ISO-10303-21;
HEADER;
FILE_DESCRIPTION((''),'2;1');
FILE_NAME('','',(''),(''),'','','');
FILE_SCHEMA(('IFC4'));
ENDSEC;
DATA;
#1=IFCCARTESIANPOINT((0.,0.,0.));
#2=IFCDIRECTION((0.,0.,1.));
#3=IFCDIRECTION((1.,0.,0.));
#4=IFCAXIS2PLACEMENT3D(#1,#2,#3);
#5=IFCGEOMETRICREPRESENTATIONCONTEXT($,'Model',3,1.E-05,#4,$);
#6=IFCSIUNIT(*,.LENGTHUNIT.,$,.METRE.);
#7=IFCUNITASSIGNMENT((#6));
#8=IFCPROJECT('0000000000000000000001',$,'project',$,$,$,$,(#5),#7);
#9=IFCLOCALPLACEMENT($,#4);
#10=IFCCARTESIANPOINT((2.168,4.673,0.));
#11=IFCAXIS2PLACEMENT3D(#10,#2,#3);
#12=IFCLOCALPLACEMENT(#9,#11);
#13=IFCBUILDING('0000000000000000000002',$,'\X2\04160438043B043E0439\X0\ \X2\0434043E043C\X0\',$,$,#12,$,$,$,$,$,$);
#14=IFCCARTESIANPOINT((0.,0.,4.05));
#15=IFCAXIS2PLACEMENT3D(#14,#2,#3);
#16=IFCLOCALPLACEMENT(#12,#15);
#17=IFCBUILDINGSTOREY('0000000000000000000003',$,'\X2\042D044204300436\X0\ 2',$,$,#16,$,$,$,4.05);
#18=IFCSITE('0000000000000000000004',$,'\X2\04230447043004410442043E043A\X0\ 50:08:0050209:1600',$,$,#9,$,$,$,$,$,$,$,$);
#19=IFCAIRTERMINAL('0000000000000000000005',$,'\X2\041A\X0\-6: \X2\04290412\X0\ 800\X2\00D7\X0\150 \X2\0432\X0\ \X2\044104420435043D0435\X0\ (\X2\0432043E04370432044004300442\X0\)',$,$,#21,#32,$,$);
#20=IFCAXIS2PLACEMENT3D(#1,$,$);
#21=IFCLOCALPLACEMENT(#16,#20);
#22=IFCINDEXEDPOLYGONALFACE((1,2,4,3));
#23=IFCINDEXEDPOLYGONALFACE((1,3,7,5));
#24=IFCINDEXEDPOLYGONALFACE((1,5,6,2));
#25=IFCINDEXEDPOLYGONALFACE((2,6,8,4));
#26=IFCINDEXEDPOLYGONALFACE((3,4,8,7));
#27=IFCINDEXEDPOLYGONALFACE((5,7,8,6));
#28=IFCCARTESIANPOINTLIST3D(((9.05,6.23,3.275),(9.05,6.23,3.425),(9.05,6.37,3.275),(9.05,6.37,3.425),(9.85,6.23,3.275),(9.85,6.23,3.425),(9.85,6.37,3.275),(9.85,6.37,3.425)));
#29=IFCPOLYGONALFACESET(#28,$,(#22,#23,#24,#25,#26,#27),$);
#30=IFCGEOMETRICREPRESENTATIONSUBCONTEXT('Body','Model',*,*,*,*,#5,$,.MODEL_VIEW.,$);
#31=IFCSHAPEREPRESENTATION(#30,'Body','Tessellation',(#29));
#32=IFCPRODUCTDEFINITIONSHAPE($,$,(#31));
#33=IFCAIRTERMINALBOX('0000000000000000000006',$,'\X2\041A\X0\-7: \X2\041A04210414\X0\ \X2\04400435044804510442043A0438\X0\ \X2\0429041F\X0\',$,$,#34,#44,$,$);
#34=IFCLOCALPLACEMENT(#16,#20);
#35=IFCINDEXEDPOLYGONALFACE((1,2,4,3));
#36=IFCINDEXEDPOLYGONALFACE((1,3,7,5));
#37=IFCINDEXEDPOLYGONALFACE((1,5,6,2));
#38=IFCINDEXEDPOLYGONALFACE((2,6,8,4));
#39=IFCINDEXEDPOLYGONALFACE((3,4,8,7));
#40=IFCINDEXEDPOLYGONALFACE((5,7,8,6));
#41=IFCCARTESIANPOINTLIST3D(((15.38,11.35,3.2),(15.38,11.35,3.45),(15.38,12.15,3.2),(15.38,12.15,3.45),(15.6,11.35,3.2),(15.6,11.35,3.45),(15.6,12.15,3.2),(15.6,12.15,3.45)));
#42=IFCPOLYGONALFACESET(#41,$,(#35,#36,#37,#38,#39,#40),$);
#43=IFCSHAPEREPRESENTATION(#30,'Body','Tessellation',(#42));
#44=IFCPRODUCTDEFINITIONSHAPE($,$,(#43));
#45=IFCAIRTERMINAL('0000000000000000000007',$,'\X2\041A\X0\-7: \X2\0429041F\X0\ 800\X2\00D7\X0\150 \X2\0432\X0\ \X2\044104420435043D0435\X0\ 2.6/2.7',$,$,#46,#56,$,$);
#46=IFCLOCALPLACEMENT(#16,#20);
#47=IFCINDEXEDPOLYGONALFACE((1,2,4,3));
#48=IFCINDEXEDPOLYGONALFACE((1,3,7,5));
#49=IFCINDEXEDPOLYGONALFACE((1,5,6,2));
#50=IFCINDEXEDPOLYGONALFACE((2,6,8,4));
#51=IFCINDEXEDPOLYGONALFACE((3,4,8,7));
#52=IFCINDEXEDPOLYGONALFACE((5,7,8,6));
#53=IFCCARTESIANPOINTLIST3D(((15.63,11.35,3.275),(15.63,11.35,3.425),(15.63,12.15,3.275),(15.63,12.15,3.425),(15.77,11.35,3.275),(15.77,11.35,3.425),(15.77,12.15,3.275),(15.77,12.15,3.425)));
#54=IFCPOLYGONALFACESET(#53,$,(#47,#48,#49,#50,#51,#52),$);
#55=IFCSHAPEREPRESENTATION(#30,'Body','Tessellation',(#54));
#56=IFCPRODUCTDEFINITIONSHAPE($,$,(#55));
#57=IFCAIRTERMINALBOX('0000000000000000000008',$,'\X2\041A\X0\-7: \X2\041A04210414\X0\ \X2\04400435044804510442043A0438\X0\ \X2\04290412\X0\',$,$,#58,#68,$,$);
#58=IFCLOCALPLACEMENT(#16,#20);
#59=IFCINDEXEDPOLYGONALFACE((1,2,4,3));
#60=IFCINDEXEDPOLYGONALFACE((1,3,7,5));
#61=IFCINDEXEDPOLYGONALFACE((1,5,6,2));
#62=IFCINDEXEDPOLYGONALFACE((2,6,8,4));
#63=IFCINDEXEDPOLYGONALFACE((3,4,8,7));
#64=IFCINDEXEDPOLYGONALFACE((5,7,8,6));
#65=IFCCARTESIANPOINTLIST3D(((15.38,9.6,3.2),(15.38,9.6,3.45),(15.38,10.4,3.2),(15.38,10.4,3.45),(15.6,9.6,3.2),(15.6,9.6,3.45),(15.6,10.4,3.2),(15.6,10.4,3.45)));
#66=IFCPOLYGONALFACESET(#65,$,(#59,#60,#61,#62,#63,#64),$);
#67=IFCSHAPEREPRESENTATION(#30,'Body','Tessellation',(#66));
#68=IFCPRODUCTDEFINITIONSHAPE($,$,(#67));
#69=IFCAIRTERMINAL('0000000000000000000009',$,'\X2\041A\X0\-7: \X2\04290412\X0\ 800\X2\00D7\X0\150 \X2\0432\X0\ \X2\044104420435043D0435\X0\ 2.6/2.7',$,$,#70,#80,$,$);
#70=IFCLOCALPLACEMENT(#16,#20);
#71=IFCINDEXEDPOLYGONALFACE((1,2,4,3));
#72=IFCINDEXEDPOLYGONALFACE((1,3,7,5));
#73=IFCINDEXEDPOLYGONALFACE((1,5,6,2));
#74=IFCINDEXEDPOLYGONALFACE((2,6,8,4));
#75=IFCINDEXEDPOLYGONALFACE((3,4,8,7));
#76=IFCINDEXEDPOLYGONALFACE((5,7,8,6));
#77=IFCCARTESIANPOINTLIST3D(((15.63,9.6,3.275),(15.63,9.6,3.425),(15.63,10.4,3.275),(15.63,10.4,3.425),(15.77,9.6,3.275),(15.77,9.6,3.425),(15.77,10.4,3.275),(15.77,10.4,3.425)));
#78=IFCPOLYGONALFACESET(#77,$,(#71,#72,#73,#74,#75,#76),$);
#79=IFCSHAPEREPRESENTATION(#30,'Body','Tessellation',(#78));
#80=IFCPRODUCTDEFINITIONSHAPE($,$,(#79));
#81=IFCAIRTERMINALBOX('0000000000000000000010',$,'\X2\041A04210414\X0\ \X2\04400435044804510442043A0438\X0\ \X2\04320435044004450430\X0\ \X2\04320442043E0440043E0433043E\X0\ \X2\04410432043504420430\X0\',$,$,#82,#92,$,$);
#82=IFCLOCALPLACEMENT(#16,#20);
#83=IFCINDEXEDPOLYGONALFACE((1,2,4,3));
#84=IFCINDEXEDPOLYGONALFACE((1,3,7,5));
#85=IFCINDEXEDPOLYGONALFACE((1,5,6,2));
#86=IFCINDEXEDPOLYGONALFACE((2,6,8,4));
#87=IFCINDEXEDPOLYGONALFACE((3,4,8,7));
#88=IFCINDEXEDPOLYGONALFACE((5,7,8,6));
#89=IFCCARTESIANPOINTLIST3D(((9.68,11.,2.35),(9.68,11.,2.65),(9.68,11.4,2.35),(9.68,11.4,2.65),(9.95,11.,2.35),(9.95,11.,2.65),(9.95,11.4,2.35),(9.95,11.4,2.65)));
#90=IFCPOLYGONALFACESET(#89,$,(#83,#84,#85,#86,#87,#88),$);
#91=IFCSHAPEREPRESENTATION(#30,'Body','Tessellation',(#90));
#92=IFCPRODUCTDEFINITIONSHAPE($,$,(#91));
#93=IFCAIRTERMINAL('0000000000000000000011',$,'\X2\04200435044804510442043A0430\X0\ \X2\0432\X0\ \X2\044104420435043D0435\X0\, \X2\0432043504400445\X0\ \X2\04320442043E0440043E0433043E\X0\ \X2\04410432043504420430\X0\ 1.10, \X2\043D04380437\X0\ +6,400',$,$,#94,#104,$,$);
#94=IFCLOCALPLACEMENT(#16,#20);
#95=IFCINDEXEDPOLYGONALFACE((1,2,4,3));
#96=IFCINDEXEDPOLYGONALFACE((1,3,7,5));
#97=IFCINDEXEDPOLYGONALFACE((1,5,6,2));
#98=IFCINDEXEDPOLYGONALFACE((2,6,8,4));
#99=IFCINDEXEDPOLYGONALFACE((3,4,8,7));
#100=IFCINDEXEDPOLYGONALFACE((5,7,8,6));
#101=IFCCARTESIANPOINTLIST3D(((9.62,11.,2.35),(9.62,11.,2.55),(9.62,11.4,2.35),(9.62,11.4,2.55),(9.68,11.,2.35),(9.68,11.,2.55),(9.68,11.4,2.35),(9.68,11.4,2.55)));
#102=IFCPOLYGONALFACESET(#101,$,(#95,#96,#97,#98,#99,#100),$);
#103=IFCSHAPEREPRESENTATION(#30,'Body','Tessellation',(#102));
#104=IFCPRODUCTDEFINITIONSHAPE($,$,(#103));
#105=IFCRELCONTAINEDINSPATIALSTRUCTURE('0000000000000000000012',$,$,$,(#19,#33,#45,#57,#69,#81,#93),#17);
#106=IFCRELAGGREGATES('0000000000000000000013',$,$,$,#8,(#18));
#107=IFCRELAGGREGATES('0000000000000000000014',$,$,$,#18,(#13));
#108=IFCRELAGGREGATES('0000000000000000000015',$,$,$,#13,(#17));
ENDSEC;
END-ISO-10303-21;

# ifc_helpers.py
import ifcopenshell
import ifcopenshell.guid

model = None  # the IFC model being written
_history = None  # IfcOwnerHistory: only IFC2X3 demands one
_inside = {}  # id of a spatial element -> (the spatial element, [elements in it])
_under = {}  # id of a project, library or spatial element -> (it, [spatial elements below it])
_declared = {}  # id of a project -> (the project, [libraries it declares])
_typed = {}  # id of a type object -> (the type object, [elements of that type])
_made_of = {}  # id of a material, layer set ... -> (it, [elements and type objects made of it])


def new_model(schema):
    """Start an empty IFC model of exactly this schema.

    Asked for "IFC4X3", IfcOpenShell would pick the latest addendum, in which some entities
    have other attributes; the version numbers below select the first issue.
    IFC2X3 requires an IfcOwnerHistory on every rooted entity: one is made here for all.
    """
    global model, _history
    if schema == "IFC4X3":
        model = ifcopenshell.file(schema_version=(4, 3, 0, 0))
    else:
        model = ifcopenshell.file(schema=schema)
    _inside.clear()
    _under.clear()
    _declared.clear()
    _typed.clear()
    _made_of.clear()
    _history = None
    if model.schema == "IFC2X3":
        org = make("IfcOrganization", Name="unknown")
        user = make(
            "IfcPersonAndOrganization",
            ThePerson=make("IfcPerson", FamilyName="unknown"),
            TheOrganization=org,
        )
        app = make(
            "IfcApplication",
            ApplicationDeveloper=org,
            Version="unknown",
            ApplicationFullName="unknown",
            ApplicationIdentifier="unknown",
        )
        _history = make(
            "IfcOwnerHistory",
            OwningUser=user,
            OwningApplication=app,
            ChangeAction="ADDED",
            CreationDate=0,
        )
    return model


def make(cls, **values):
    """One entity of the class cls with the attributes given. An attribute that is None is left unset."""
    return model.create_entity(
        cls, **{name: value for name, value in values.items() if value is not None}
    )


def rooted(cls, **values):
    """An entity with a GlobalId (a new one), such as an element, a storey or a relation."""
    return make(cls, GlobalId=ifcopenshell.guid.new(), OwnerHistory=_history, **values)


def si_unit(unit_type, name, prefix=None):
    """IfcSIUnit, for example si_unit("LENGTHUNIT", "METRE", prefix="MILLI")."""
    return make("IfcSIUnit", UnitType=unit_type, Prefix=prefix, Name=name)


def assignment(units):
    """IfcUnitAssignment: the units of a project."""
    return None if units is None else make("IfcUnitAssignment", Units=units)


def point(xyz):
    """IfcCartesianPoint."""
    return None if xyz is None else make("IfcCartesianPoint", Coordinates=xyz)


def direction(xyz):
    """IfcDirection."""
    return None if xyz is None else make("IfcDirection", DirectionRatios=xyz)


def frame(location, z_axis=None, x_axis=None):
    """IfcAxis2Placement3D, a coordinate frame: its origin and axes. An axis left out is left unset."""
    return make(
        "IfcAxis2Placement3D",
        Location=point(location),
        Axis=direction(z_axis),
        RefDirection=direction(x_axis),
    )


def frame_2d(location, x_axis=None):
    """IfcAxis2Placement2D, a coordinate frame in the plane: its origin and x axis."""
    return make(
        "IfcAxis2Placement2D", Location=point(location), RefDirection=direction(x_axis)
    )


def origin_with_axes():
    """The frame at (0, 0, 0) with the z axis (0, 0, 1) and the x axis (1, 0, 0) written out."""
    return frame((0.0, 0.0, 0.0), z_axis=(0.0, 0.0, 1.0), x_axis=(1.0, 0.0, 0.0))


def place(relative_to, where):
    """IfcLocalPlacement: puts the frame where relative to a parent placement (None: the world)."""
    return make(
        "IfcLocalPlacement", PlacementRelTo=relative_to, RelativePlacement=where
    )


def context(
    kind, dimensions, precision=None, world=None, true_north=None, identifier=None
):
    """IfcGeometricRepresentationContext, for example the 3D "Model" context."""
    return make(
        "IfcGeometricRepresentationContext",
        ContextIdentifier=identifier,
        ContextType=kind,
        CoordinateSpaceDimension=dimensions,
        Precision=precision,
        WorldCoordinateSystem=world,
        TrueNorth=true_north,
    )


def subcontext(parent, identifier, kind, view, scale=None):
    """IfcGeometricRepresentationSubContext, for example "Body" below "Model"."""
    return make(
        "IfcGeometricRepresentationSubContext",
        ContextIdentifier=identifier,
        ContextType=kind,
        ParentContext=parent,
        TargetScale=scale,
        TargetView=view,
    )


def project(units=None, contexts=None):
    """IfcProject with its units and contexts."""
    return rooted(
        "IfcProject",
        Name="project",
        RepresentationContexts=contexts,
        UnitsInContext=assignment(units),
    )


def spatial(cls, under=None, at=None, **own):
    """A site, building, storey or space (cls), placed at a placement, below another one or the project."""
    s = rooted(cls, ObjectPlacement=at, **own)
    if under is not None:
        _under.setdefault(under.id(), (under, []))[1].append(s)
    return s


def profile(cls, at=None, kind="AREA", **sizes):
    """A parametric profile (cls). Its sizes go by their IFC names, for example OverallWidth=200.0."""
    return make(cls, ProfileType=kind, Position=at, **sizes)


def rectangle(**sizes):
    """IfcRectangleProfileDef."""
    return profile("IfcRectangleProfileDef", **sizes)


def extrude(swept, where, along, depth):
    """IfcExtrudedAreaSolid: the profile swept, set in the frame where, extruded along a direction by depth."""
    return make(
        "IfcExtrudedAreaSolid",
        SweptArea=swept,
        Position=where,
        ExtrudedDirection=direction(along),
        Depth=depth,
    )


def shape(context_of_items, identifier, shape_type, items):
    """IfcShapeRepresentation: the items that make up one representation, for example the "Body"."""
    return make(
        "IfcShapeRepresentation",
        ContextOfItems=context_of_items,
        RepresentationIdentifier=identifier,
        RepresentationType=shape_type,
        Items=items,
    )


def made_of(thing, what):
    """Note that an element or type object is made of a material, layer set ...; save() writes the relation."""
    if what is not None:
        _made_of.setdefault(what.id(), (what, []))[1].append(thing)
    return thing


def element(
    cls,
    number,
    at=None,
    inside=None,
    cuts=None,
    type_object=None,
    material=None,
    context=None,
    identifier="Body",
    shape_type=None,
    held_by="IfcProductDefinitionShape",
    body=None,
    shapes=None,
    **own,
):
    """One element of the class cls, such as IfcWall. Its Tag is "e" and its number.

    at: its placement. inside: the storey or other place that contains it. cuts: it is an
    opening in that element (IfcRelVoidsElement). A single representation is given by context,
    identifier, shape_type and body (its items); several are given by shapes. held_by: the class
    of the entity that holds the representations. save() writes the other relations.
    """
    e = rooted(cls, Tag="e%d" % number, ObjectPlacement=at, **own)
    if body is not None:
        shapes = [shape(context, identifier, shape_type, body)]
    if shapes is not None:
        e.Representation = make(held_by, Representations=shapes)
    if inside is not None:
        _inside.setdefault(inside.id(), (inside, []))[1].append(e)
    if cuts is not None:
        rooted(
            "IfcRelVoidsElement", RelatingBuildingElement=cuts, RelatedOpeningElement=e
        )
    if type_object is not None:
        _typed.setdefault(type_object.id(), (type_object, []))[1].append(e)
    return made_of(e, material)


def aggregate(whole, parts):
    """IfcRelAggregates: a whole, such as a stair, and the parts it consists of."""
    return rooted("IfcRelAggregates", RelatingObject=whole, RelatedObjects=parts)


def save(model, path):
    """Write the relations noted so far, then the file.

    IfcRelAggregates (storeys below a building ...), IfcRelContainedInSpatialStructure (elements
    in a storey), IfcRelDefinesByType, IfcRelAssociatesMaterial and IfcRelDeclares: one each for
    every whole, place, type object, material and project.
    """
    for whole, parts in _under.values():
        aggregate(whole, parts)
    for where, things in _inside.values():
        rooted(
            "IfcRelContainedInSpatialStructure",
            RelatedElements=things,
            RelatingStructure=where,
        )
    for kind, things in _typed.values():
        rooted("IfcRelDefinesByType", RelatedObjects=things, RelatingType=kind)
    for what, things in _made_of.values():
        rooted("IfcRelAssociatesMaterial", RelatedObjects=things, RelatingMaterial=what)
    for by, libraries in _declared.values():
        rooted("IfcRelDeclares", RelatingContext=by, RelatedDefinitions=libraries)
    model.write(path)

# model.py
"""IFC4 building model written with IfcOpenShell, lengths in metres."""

from ifc_helpers import new_model, si_unit, frame, frame_2d, origin_with_axes, place, context, subcontext, project, spatial, rectangle, extrude, element, save


model = new_model("IFC4")

# Units and contexts
model_context = context("Model", 3, precision=1e-05, world=origin_with_axes())
body_context = subcontext(model_context, "Body", "Model", "MODEL_VIEW")
ifc_project = project(units=[si_unit("LENGTHUNIT", "METRE")], contexts=[model_context])

# Site, building, storey
site_placement = place(None, origin_with_axes())
site = spatial("IfcSite", under=ifc_project, at=site_placement, Name="Участок 50:08:0050209:1600")
building_placement = place(site_placement, frame((2.168, 4.673, 0.0), z_axis=(0.0, 0.0, 1.0), x_axis=(1.0, 0.0, 0.0)))
building = spatial("IfcBuilding", under=site, at=building_placement, Name="Жилой дом")
storey_placement = place(building_placement, frame((0.0, 0.0, 4.05), z_axis=(0.0, 0.0, 1.0), x_axis=(1.0, 0.0, 0.0)))
storey = spatial("IfcBuildingStorey", under=building, at=storey_placement, Name="Этаж 2", Elevation=4.05)

# Air terminal
air_terminal_1_placement = place(storey_placement, frame((0.0, 0.0, -4.05), z_axis=(0.0, 0.0, 1.0), x_axis=(1.0, 0.0, 0.0)))
element("IfcAirTerminal", 1, at=air_terminal_1_placement, inside=storey, Name="К-6: ЩВ 800×150 в стене (возврат)", context=body_context, shape_type="SweptSolid", body=[
    extrude(rectangle(XDim=0.8, YDim=0.14, at=frame_2d((0.4, 0.07))), frame((9.05, 6.23, 7.325), z_axis=(0.0, 0.0, 1.0), x_axis=(1.0, 0.0, 0.0)), (0.0, 0.0, 1.0), 0.15),
])

# Air terminal box
air_terminal_box_1_placement = place(storey_placement, frame((0.0, 0.0, -4.05), z_axis=(0.0, 0.0, 1.0), x_axis=(1.0, 0.0, 0.0)))
element("IfcAirTerminalBox", 2, at=air_terminal_box_1_placement, inside=storey, Name="К-7: КСД решётки ЩП", context=body_context, shape_type="SweptSolid", body=[
    extrude(rectangle(XDim=0.22, YDim=0.8, at=frame_2d((0.11, 0.4))), frame((15.38, 11.35, 7.25), z_axis=(0.0, 0.0, 1.0), x_axis=(1.0, 0.0, 0.0)), (0.0, 0.0, 1.0), 0.25),
])

# Air terminal
air_terminal_2_placement = place(storey_placement, frame((0.0, 0.0, -4.05), z_axis=(0.0, 0.0, 1.0), x_axis=(1.0, 0.0, 0.0)))
element("IfcAirTerminal", 3, at=air_terminal_2_placement, inside=storey, Name="К-7: ЩП 800×150 в стене 2.6/2.7", context=body_context, shape_type="SweptSolid", body=[
    extrude(rectangle(XDim=0.14, YDim=0.8, at=frame_2d((0.07, 0.4))), frame((15.63, 11.35, 7.325), z_axis=(0.0, 0.0, 1.0), x_axis=(1.0, 0.0, 0.0)), (0.0, 0.0, 1.0), 0.15),
])

# Air terminal box
air_terminal_box_2_placement = place(storey_placement, frame((0.0, 0.0, -4.05), z_axis=(0.0, 0.0, 1.0), x_axis=(1.0, 0.0, 0.0)))
element("IfcAirTerminalBox", 4, at=air_terminal_box_2_placement, inside=storey, Name="К-7: КСД решётки ЩВ", context=body_context, shape_type="SweptSolid", body=[
    extrude(rectangle(XDim=0.22, YDim=0.8, at=frame_2d((0.11, 0.4))), frame((15.38, 9.6, 7.25), z_axis=(0.0, 0.0, 1.0), x_axis=(1.0, 0.0, 0.0)), (0.0, 0.0, 1.0), 0.25),
])

# Air terminal
air_terminal_3_placement = place(storey_placement, frame((0.0, 0.0, -4.05), z_axis=(0.0, 0.0, 1.0), x_axis=(1.0, 0.0, 0.0)))
element("IfcAirTerminal", 5, at=air_terminal_3_placement, inside=storey, Name="К-7: ЩВ 800×150 в стене 2.6/2.7", context=body_context, shape_type="SweptSolid", body=[
    extrude(rectangle(XDim=0.14, YDim=0.8, at=frame_2d((0.07, 0.4))), frame((15.63, 9.6, 7.325), z_axis=(0.0, 0.0, 1.0), x_axis=(1.0, 0.0, 0.0)), (0.0, 0.0, 1.0), 0.15),
])

# Air terminal box
air_terminal_box_3_placement = place(storey_placement, frame((0.0, 0.0, -4.05), z_axis=(0.0, 0.0, 1.0), x_axis=(1.0, 0.0, 0.0)))
element("IfcAirTerminalBox", 6, at=air_terminal_box_3_placement, inside=storey, Name="КСД решётки верха второго света", context=body_context, shape_type="SweptSolid", body=[
    extrude(rectangle(XDim=0.27, YDim=0.4, at=frame_2d((0.135, 0.2))), frame((9.68, 11.0, 6.4), z_axis=(0.0, 0.0, 1.0), x_axis=(1.0, 0.0, 0.0)), (0.0, 0.0, 1.0), 0.3),
])

# Air terminal
air_terminal_4_placement = place(storey_placement, frame((0.0, 0.0, -4.05), z_axis=(0.0, 0.0, 1.0), x_axis=(1.0, 0.0, 0.0)))
element("IfcAirTerminal", 7, at=air_terminal_4_placement, inside=storey, Name="Решётка в стене, верх второго света 1.10, низ +6,400", context=body_context, shape_type="SweptSolid", body=[
    extrude(rectangle(XDim=0.06, YDim=0.4, at=frame_2d((0.03, 0.2))), frame((9.62, 11.0, 6.4), z_axis=(0.0, 0.0, 1.0), x_axis=(1.0, 0.0, 0.0)), (0.0, 0.0, 1.0), 0.2),
])

save(model, "model.ifc")
